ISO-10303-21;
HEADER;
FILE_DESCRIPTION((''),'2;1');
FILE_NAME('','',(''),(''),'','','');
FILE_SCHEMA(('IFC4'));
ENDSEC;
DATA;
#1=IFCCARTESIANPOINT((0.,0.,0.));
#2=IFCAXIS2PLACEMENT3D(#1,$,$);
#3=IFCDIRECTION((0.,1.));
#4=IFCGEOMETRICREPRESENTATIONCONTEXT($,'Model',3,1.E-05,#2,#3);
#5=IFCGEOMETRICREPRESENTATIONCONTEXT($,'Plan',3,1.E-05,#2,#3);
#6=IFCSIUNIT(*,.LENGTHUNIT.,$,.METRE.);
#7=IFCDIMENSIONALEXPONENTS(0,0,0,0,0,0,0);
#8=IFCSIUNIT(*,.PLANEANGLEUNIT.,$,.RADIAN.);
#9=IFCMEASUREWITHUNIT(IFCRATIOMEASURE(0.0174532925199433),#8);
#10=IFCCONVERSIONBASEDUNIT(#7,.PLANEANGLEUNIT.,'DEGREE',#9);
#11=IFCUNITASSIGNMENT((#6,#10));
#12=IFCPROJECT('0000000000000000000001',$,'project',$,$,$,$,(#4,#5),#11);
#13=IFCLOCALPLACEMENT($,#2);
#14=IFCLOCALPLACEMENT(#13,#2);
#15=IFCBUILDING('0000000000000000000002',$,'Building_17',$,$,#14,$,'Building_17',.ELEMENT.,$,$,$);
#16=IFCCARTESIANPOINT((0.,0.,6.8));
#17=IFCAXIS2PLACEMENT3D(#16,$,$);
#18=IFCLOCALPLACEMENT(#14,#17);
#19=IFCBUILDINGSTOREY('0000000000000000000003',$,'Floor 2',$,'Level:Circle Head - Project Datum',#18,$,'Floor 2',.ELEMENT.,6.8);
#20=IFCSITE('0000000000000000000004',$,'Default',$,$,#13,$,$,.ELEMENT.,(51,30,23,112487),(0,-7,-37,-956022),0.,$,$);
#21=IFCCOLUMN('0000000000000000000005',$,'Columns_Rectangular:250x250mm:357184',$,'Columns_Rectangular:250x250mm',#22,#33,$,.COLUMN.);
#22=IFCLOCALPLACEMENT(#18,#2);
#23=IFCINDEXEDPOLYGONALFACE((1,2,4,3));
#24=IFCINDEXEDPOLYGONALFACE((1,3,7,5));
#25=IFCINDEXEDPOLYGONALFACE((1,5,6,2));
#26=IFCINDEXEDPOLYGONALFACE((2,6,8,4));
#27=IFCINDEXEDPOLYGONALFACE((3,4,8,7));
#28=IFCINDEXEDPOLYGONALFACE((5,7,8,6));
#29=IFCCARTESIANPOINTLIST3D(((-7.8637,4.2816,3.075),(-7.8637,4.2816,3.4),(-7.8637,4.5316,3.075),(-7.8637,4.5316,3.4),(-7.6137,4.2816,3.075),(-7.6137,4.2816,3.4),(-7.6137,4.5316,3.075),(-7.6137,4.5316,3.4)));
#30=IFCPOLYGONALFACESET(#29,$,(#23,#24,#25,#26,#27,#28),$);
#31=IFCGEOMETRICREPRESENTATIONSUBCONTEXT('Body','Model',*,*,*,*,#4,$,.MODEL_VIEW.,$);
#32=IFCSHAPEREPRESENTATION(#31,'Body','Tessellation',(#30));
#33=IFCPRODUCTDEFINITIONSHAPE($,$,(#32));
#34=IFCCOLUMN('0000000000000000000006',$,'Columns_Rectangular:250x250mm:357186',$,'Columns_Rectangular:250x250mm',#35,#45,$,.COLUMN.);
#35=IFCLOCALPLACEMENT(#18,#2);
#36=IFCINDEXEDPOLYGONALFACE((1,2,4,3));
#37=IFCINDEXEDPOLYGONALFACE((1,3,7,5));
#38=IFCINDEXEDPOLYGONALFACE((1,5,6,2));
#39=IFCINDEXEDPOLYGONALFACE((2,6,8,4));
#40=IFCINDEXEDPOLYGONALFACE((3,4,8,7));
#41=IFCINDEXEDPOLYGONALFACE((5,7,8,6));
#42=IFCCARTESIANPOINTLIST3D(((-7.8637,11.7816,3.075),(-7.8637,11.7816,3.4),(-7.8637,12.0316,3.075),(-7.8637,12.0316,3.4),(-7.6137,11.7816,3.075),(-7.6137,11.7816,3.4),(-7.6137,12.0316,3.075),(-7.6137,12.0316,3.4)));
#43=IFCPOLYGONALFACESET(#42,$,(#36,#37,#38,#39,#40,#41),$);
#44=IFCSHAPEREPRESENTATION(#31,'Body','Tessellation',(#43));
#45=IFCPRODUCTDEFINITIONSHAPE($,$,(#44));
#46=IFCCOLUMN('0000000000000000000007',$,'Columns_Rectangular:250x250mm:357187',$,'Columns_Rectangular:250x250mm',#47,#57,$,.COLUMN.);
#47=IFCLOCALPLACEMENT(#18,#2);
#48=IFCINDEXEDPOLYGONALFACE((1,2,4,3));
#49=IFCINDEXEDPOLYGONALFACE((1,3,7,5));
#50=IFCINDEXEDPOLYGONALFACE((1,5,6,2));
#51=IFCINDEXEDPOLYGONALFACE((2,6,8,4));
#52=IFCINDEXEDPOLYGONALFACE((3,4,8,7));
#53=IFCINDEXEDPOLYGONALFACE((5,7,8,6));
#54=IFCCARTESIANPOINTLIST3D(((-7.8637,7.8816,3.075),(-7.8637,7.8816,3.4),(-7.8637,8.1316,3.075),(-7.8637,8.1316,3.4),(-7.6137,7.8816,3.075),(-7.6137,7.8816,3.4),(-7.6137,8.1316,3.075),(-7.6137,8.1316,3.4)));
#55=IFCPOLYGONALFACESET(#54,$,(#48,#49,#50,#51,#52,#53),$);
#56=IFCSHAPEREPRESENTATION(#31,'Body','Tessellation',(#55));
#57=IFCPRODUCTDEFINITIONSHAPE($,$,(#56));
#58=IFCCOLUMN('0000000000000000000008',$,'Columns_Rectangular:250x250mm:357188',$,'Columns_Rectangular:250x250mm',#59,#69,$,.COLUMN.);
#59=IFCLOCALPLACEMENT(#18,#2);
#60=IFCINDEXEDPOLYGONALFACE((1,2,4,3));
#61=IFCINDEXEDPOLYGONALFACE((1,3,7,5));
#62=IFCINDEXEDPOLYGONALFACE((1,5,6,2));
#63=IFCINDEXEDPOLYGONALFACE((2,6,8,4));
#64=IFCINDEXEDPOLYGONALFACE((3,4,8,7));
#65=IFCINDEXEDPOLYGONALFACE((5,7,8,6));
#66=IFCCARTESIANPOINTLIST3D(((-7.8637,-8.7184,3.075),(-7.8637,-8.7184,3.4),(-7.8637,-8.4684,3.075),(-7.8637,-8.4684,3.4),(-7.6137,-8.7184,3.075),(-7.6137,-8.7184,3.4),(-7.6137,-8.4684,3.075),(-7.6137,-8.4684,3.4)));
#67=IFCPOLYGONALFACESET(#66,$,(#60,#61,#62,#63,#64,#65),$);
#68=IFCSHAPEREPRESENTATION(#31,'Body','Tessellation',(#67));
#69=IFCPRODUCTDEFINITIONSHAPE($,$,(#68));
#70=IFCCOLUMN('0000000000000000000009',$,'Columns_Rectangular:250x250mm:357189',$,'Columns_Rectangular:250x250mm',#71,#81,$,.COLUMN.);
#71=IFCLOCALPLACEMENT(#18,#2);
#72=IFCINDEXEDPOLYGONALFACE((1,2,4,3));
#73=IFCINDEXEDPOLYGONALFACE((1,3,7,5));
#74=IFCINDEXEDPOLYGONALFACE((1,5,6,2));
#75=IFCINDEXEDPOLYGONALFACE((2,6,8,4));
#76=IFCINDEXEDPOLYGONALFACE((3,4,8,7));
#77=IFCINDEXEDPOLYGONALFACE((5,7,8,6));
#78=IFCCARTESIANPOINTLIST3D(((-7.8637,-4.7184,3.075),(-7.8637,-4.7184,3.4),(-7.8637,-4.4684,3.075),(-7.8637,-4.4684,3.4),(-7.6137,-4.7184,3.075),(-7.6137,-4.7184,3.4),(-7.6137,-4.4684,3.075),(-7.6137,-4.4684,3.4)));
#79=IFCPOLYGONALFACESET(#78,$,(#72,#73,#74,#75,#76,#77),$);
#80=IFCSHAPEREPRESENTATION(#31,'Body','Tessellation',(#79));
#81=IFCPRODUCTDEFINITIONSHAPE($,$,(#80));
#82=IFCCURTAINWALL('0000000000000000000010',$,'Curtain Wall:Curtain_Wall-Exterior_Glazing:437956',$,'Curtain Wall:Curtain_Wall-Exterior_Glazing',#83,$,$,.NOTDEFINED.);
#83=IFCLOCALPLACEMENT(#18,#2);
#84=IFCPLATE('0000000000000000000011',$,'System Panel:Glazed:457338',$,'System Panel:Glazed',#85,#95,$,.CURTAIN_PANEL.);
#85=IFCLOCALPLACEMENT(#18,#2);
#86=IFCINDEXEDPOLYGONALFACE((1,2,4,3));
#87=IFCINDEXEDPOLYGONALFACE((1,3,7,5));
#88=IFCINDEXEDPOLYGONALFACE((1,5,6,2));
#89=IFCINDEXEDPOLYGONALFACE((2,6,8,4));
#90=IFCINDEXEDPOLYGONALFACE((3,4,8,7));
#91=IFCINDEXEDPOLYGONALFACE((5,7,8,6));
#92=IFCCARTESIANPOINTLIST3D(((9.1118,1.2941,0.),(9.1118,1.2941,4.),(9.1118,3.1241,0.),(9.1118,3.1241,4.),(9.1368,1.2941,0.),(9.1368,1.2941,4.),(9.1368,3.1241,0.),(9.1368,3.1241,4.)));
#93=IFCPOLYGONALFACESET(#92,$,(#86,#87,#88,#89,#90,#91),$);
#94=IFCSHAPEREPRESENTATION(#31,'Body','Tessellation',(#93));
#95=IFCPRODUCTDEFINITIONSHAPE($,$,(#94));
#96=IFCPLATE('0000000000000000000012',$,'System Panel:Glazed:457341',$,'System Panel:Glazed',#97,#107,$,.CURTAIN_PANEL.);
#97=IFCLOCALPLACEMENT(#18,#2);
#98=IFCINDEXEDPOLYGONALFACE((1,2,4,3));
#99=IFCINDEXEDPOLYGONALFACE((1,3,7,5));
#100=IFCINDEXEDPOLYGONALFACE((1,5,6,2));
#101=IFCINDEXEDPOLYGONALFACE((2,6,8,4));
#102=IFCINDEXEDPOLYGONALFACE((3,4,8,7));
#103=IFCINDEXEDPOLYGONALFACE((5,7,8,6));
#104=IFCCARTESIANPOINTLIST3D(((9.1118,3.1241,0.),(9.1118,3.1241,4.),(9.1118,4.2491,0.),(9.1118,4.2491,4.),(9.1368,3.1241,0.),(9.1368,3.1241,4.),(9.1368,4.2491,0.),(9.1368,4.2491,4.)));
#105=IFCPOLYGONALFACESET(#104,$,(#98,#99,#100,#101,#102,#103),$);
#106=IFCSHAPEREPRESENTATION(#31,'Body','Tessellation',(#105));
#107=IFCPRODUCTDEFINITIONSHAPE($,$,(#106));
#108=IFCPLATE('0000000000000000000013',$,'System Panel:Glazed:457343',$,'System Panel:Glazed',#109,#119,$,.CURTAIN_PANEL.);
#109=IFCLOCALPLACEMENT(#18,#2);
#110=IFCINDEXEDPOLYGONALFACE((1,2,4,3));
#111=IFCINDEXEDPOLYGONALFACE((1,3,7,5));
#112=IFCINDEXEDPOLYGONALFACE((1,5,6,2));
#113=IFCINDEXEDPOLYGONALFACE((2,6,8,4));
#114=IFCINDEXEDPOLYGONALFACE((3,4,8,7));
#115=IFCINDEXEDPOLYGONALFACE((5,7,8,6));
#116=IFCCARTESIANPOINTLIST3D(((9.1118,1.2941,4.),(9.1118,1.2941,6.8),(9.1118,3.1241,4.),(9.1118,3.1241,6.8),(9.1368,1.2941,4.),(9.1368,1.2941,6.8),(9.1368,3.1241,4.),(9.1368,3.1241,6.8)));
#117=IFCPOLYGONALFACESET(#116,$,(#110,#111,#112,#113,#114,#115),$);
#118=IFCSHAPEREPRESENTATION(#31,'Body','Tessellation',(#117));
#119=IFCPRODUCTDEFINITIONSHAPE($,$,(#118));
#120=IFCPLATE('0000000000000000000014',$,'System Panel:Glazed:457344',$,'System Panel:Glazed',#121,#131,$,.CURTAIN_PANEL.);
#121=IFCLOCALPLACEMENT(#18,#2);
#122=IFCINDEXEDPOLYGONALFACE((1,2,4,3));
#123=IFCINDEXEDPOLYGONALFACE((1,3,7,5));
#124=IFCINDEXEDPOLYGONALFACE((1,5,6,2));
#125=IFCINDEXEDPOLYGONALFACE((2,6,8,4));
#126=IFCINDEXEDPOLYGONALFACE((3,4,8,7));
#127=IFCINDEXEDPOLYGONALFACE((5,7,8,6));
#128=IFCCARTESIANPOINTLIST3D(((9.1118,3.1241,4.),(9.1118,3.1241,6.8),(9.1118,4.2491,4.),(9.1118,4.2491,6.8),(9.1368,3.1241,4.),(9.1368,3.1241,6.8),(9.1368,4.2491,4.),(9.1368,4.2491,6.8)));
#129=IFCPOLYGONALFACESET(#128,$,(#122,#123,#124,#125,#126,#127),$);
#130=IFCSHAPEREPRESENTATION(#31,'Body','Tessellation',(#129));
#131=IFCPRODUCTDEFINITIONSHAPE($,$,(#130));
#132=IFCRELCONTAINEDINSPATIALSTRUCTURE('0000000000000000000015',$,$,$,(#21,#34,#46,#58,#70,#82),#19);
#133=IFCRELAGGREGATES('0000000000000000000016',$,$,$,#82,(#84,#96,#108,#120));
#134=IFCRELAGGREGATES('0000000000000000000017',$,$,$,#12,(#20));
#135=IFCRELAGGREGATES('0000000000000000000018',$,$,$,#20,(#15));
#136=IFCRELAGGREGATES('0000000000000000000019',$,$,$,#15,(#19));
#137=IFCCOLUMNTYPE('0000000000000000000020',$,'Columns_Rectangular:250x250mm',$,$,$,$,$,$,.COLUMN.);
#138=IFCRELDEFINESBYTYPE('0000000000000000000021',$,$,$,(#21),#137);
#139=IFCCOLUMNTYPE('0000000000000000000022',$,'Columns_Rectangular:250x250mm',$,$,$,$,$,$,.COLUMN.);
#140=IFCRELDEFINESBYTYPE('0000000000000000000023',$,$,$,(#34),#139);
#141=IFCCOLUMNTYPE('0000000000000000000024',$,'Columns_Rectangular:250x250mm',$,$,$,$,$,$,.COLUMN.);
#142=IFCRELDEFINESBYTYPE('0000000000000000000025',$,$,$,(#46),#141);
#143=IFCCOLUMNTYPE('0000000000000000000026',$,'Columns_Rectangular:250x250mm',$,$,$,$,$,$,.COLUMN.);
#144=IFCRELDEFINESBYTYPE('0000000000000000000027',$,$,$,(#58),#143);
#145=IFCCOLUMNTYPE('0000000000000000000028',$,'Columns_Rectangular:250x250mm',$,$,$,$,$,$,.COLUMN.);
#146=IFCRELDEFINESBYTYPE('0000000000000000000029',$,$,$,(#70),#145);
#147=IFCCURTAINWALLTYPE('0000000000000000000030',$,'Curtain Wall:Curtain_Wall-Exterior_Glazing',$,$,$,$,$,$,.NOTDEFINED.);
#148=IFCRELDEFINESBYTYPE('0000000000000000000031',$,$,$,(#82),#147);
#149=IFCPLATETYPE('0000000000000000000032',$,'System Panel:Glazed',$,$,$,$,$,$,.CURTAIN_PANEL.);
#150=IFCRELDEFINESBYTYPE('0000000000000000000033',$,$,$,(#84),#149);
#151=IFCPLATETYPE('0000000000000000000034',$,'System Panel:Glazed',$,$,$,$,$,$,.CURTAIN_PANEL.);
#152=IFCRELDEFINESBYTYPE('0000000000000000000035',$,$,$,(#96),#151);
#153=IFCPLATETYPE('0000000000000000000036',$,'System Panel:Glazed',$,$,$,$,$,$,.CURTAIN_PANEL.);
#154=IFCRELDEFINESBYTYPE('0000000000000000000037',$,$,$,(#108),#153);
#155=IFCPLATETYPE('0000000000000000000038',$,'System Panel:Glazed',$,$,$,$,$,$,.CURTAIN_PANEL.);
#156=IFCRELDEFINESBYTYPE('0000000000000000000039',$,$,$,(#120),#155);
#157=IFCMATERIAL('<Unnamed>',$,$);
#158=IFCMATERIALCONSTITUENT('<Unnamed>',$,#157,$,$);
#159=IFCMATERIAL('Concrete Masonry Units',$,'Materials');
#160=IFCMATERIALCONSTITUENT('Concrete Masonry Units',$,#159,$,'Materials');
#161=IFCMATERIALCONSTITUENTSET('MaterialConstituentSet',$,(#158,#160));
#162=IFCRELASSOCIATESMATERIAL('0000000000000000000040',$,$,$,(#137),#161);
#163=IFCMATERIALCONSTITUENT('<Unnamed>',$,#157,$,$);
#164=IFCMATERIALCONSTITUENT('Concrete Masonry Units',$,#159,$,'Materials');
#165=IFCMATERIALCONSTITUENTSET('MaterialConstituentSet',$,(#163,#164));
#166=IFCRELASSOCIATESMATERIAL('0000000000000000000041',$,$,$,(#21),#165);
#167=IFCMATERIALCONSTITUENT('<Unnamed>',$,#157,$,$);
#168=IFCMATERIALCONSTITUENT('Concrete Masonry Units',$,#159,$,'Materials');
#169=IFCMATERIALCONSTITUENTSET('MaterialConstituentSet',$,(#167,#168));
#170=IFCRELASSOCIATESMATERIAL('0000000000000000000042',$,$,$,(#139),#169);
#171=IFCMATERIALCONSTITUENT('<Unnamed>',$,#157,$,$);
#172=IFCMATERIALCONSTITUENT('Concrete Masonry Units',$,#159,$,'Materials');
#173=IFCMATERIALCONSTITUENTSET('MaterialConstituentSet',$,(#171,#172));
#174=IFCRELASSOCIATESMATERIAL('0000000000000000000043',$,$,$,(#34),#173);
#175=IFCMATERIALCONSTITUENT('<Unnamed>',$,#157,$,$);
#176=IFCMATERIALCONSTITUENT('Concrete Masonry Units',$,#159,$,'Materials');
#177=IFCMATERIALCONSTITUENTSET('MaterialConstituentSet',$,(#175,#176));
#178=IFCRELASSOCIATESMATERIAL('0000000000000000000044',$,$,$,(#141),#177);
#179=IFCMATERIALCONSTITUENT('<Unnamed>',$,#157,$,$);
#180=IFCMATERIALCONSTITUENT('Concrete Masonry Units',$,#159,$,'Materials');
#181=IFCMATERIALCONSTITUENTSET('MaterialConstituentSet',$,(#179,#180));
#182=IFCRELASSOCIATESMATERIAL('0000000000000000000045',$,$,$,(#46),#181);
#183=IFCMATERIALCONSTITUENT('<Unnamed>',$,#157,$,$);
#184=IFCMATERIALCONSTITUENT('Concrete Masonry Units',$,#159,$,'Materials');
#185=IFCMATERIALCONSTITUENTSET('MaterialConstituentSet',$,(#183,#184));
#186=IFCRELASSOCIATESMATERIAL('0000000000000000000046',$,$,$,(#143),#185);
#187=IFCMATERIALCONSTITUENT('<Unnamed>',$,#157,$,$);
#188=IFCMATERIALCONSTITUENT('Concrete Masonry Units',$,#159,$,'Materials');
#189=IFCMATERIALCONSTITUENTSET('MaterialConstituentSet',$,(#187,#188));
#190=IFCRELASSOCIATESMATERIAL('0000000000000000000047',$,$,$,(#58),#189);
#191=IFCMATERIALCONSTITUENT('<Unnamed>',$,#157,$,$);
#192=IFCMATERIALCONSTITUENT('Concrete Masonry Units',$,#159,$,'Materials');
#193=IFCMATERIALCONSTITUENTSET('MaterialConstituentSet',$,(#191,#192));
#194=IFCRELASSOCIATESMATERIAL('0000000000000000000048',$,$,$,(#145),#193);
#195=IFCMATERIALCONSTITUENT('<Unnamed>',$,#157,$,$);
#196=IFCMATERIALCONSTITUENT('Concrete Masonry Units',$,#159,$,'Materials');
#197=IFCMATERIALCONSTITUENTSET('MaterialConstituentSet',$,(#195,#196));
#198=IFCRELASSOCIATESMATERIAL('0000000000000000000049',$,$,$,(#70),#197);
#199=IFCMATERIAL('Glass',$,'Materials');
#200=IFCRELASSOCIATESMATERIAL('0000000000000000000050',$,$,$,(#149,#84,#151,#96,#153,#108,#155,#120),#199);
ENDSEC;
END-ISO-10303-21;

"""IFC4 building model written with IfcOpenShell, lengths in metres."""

from ifc_helpers import new_model, entity, si_unit, converted_unit, direction, frame, origin, place, context, subcontext, project, spatial, indexed_curve, outline, extrude, source, transform, mapped, material, constituent, constituent_set, type_object, type_shapes, element, aggregate, save


model = new_model("IFC4")

# Units and contexts
model_context = context("Model", 3, precision=1e-05, world=origin(), true_north=direction((0.0, 1.0)))
plan_context = context("Plan", 3, precision=1e-05, world=origin(), true_north=direction((0.0, 1.0)))
body_context = subcontext(model_context, "Body", "Model", "MODEL_VIEW")
ifc_project = project(units=[si_unit("LENGTHUNIT", "METRE"), converted_unit("PLANEANGLEUNIT", "DEGREE", entity("IfcRatioMeasure", 0.0174532925199433), si_unit("PLANEANGLEUNIT", "RADIAN"), dimensions=[0, 0, 0, 0, 0, 0, 0])], contexts=[model_context, plan_context])

# Site, building, storey
site_placement = place(None, origin())
site = spatial("IfcSite", under=ifc_project, at=site_placement, Name="Default", CompositionType="ELEMENT", RefLatitude=(51, 30, 23, 112487), RefLongitude=(0, -7, -37, -956022), RefElevation=0.0)
building_placement = place(site_placement, origin())
building = spatial("IfcBuilding", under=site, at=building_placement, Name="Building_17", LongName="Building_17", CompositionType="ELEMENT")
storey_placement = place(building_placement, frame((0.0, 0.0, 6.8)))
storey = spatial("IfcBuildingStorey", under=building, at=storey_placement, Name="Floor 2", ObjectType="Level:Circle Head - Project Datum", LongName="Floor 2", CompositionType="ELEMENT", Elevation=6.8)

# Columns
ifc_material_1 = material(Name="<Unnamed>")
ifc_material_2 = material(Name="Concrete Masonry Units", Category="Materials")
ifc_constituent_1 = constituent(ifc_material_1, Name="<Unnamed>")
ifc_constituent_2 = constituent(ifc_material_2, Name="Concrete Masonry Units", Category="Materials")
ifc_constituent_set_1 = constituent_set(constituents=[ifc_constituent_1, ifc_constituent_2], Name="MaterialConstituentSet")
ifc_constituent_3 = constituent(ifc_material_1, Name="<Unnamed>")
ifc_constituent_4 = constituent(ifc_material_2, Name="Concrete Masonry Units", Category="Materials")
ifc_constituent_set_2 = constituent_set(constituents=[ifc_constituent_3, ifc_constituent_4], Name="MaterialConstituentSet")
column_type_1 = type_object("IfcColumnType", Name="Columns_Rectangular:250x250mm", PredefinedType="COLUMN", material=ifc_constituent_set_2)
shared_shape_1 = source(origin(), body_context, "Body", "SweptSolid", [
    extrude(outline(indexed_curve([(-0.125, -0.125), (0.125, -0.125), (0.125, 0.125), (-0.125, 0.125), (-0.125, -0.125)], self_intersect=False)), frame((-7.7387, 4.4066, 9.875), z_axis=(0.0, 0.0, 1.0), x_axis=(0.0, -1.0, 0.0)), (0.0, 0.0, 1.0), 0.325),
])
type_shapes(column_type_1, [shared_shape_1])
column_1_placement = place(storey_placement, frame((0.0, 0.0, -6.8)))
element("IfcColumn", 1, at=column_1_placement, inside=storey, type_object=column_type_1, material=ifc_constituent_set_1, Name="Columns_Rectangular:250x250mm:357184", ObjectType="Columns_Rectangular:250x250mm", PredefinedType="COLUMN", context=body_context, shape_type="MappedRepresentation", body=[
    mapped(shared_shape_1, transform((0.0, 0.0, 0.0), scale=1.0)),
])
ifc_constituent_5 = constituent(ifc_material_1, Name="<Unnamed>")
ifc_constituent_6 = constituent(ifc_material_2, Name="Concrete Masonry Units", Category="Materials")
ifc_constituent_set_3 = constituent_set(constituents=[ifc_constituent_5, ifc_constituent_6], Name="MaterialConstituentSet")
ifc_constituent_7 = constituent(ifc_material_1, Name="<Unnamed>")
ifc_constituent_8 = constituent(ifc_material_2, Name="Concrete Masonry Units", Category="Materials")
ifc_constituent_set_4 = constituent_set(constituents=[ifc_constituent_7, ifc_constituent_8], Name="MaterialConstituentSet")
column_type_2 = type_object("IfcColumnType", Name="Columns_Rectangular:250x250mm", PredefinedType="COLUMN", material=ifc_constituent_set_4)
shared_shape_2 = source(origin(), body_context, "Body", "SweptSolid", [
    extrude(outline(indexed_curve([(-0.125, -0.125), (0.125, -0.125), (0.125, 0.125), (-0.125, 0.125), (-0.125, -0.125)], self_intersect=False)), frame((-7.7387, 11.9066, 9.875), z_axis=(0.0, 0.0, 1.0), x_axis=(0.0, -1.0, 0.0)), (0.0, 0.0, 1.0), 0.325),
])
type_shapes(column_type_2, [shared_shape_2])
column_2_placement = place(storey_placement, frame((0.0, 0.0, -6.8)))
element("IfcColumn", 2, at=column_2_placement, inside=storey, type_object=column_type_2, material=ifc_constituent_set_3, Name="Columns_Rectangular:250x250mm:357186", ObjectType="Columns_Rectangular:250x250mm", PredefinedType="COLUMN", context=body_context, shape_type="MappedRepresentation", body=[
    mapped(shared_shape_2, transform((0.0, 0.0, 0.0), scale=1.0)),
])
ifc_constituent_9 = constituent(ifc_material_1, Name="<Unnamed>")
ifc_constituent_10 = constituent(ifc_material_2, Name="Concrete Masonry Units", Category="Materials")
ifc_constituent_set_5 = constituent_set(constituents=[ifc_constituent_9, ifc_constituent_10], Name="MaterialConstituentSet")
ifc_constituent_11 = constituent(ifc_material_1, Name="<Unnamed>")
ifc_constituent_12 = constituent(ifc_material_2, Name="Concrete Masonry Units", Category="Materials")
ifc_constituent_set_6 = constituent_set(constituents=[ifc_constituent_11, ifc_constituent_12], Name="MaterialConstituentSet")
column_type_3 = type_object("IfcColumnType", Name="Columns_Rectangular:250x250mm", PredefinedType="COLUMN", material=ifc_constituent_set_6)
shared_shape_3 = source(origin(), body_context, "Body", "SweptSolid", [
    extrude(outline(indexed_curve([(-0.125, -0.125), (0.125, -0.125), (0.125, 0.125), (-0.125, 0.125), (-0.125, -0.125)], self_intersect=False)), frame((-7.7387, 8.0066, 9.875), z_axis=(0.0, 0.0, 1.0), x_axis=(0.0, -1.0, 0.0)), (0.0, 0.0, 1.0), 0.325),
])
type_shapes(column_type_3, [shared_shape_3])
column_3_placement = place(storey_placement, frame((0.0, 0.0, -6.8)))
element("IfcColumn", 3, at=column_3_placement, inside=storey, type_object=column_type_3, material=ifc_constituent_set_5, Name="Columns_Rectangular:250x250mm:357187", ObjectType="Columns_Rectangular:250x250mm", PredefinedType="COLUMN", context=body_context, shape_type="MappedRepresentation", body=[
    mapped(shared_shape_3, transform((0.0, 0.0, 0.0), scale=1.0)),
])
ifc_constituent_13 = constituent(ifc_material_1, Name="<Unnamed>")
ifc_constituent_14 = constituent(ifc_material_2, Name="Concrete Masonry Units", Category="Materials")
ifc_constituent_set_7 = constituent_set(constituents=[ifc_constituent_13, ifc_constituent_14], Name="MaterialConstituentSet")
ifc_constituent_15 = constituent(ifc_material_1, Name="<Unnamed>")
ifc_constituent_16 = constituent(ifc_material_2, Name="Concrete Masonry Units", Category="Materials")
ifc_constituent_set_8 = constituent_set(constituents=[ifc_constituent_15, ifc_constituent_16], Name="MaterialConstituentSet")
column_type_4 = type_object("IfcColumnType", Name="Columns_Rectangular:250x250mm", PredefinedType="COLUMN", material=ifc_constituent_set_8)
shared_shape_4 = source(origin(), body_context, "Body", "SweptSolid", [
    extrude(outline(indexed_curve([(-0.125, -0.125), (0.125, -0.125), (0.125, 0.125), (-0.125, 0.125), (-0.125, -0.125)], self_intersect=False)), frame((-7.7387, -8.5934, 9.875), z_axis=(0.0, 0.0, 1.0), x_axis=(0.0, -1.0, 0.0)), (0.0, 0.0, 1.0), 0.325),
])
type_shapes(column_type_4, [shared_shape_4])
column_4_placement = place(storey_placement, frame((0.0, 0.0, -6.8)))
element("IfcColumn", 4, at=column_4_placement, inside=storey, type_object=column_type_4, material=ifc_constituent_set_7, Name="Columns_Rectangular:250x250mm:357188", ObjectType="Columns_Rectangular:250x250mm", PredefinedType="COLUMN", context=body_context, shape_type="MappedRepresentation", body=[
    mapped(shared_shape_4, transform((0.0, 0.0, 0.0), scale=1.0)),
])
ifc_constituent_17 = constituent(ifc_material_1, Name="<Unnamed>")
ifc_constituent_18 = constituent(ifc_material_2, Name="Concrete Masonry Units", Category="Materials")
ifc_constituent_set_9 = constituent_set(constituents=[ifc_constituent_17, ifc_constituent_18], Name="MaterialConstituentSet")
ifc_constituent_19 = constituent(ifc_material_1, Name="<Unnamed>")
ifc_constituent_20 = constituent(ifc_material_2, Name="Concrete Masonry Units", Category="Materials")
ifc_constituent_set_10 = constituent_set(constituents=[ifc_constituent_19, ifc_constituent_20], Name="MaterialConstituentSet")
column_type_5 = type_object("IfcColumnType", Name="Columns_Rectangular:250x250mm", PredefinedType="COLUMN", material=ifc_constituent_set_10)
shared_shape_5 = source(origin(), body_context, "Body", "SweptSolid", [
    extrude(outline(indexed_curve([(-0.125, -0.125), (0.125, -0.125), (0.125, 0.125), (-0.125, 0.125), (-0.125, -0.125)], self_intersect=False)), frame((-7.7387, -4.5934, 9.875), z_axis=(0.0, 0.0, 1.0), x_axis=(0.0, -1.0, 0.0)), (0.0, 0.0, 1.0), 0.325),
])
type_shapes(column_type_5, [shared_shape_5])
column_5_placement = place(storey_placement, frame((0.0, 0.0, -6.8)))
element("IfcColumn", 5, at=column_5_placement, inside=storey, type_object=column_type_5, material=ifc_constituent_set_9, Name="Columns_Rectangular:250x250mm:357189", ObjectType="Columns_Rectangular:250x250mm", PredefinedType="COLUMN", context=body_context, shape_type="MappedRepresentation", body=[
    mapped(shared_shape_5, transform((0.0, 0.0, 0.0), scale=1.0)),
])

# Curtain wall, plates
curtain_wall_type = type_object("IfcCurtainWallType", Name="Curtain Wall:Curtain_Wall-Exterior_Glazing", PredefinedType="NOTDEFINED")
curtain_wall_placement = place(storey_placement, frame((0.0, 0.0, -6.8)))
curtain_wall = element("IfcCurtainWall", 6, at=curtain_wall_placement, inside=storey, type_object=curtain_wall_type, Name="Curtain Wall:Curtain_Wall-Exterior_Glazing:437956", ObjectType="Curtain Wall:Curtain_Wall-Exterior_Glazing", PredefinedType="NOTDEFINED")
ifc_material_3 = material(Name="Glass", Category="Materials")
plate_type_1 = type_object("IfcPlateType", Name="System Panel:Glazed", PredefinedType="CURTAIN_PANEL", material=ifc_material_3)
shared_shape_6 = source(origin(), body_context, "Body", "SweptSolid", [
    extrude(outline(indexed_curve([(-0.0125, -0.915), (0.0125, -0.915), (0.0125, 0.915), (-0.0125, 0.915), (-0.0125, -0.915)], self_intersect=False)), frame((0.0, 0.037, 0.0), z_axis=(0.0, 0.0, 1.0), x_axis=(0.0, 1.0, 0.0)), (0.0, 0.0, 1.0), 4.0),
])
type_shapes(plate_type_1, [shared_shape_6])
plate_1_placement = place(curtain_wall_placement, frame((9.1613, 2.2091, 6.8), z_axis=(0.0, 0.0, 1.0), x_axis=(0.0, 1.0, 0.0)))
plate_1 = element("IfcPlate", 7, at=plate_1_placement, type_object=plate_type_1, material=ifc_material_3, Name="System Panel:Glazed:457338", ObjectType="System Panel:Glazed", PredefinedType="CURTAIN_PANEL", context=body_context, shape_type="MappedRepresentation", body=[
    mapped(shared_shape_6, transform((0.0, 0.0, 0.0), scale=1.0)),
])
plate_type_2 = type_object("IfcPlateType", Name="System Panel:Glazed", PredefinedType="CURTAIN_PANEL", material=ifc_material_3)
shared_shape_7 = source(origin(), body_context, "Body", "SweptSolid", [
    extrude(outline(indexed_curve([(-0.0125, -0.5625), (0.0125, -0.5625), (0.0125, 0.5625), (-0.0125, 0.5625), (-0.0125, -0.5625)], self_intersect=False)), frame((0.0, 0.037, 0.0), z_axis=(0.0, 0.0, 1.0), x_axis=(0.0, 1.0, 0.0)), (0.0, 0.0, 1.0), 4.0),
])
type_shapes(plate_type_2, [shared_shape_7])
plate_2_placement = place(curtain_wall_placement, frame((9.1613, 3.6866, 6.8), z_axis=(0.0, 0.0, 1.0), x_axis=(0.0, 1.0, 0.0)))
plate_2 = element("IfcPlate", 8, at=plate_2_placement, type_object=plate_type_2, material=ifc_material_3, Name="System Panel:Glazed:457341", ObjectType="System Panel:Glazed", PredefinedType="CURTAIN_PANEL", context=body_context, shape_type="MappedRepresentation", body=[
    mapped(shared_shape_7, transform((0.0, 0.0, 0.0), scale=1.0)),
])
plate_type_3 = type_object("IfcPlateType", Name="System Panel:Glazed", PredefinedType="CURTAIN_PANEL", material=ifc_material_3)
shared_shape_8 = source(origin(), body_context, "Body", "SweptSolid", [
    extrude(outline(indexed_curve([(-0.0125, -0.915), (0.0125, -0.915), (0.0125, 0.915), (-0.0125, 0.915), (-0.0125, -0.915)], self_intersect=False)), frame((0.0, 0.037, 0.0), z_axis=(0.0, 0.0, 1.0), x_axis=(0.0, 1.0, 0.0)), (0.0, 0.0, 1.0), 2.8),
])
type_shapes(plate_type_3, [shared_shape_8])
plate_3_placement = place(curtain_wall_placement, frame((9.1613, 2.2091, 10.8), z_axis=(0.0, 0.0, 1.0), x_axis=(0.0, 1.0, 0.0)))
plate_3 = element("IfcPlate", 9, at=plate_3_placement, type_object=plate_type_3, material=ifc_material_3, Name="System Panel:Glazed:457343", ObjectType="System Panel:Glazed", PredefinedType="CURTAIN_PANEL", context=body_context, shape_type="MappedRepresentation", body=[
    mapped(shared_shape_8, transform((0.0, 0.0, 0.0), scale=1.0)),
])
plate_type_4 = type_object("IfcPlateType", Name="System Panel:Glazed", PredefinedType="CURTAIN_PANEL", material=ifc_material_3)
shared_shape_9 = source(origin(), body_context, "Body", "SweptSolid", [
    extrude(outline(indexed_curve([(-0.0125, -0.5625), (0.0125, -0.5625), (0.0125, 0.5625), (-0.0125, 0.5625), (-0.0125, -0.5625)], self_intersect=False)), frame((0.0, 0.037, 0.0), z_axis=(0.0, 0.0, 1.0), x_axis=(0.0, 1.0, 0.0)), (0.0, 0.0, 1.0), 2.8),
])
type_shapes(plate_type_4, [shared_shape_9])
plate_4_placement = place(curtain_wall_placement, frame((9.1613, 3.6866, 10.8), z_axis=(0.0, 0.0, 1.0), x_axis=(0.0, 1.0, 0.0)))
plate_4 = element("IfcPlate", 10, at=plate_4_placement, type_object=plate_type_4, material=ifc_material_3, Name="System Panel:Glazed:457344", ObjectType="System Panel:Glazed", PredefinedType="CURTAIN_PANEL", context=body_context, shape_type="MappedRepresentation", body=[
    mapped(shared_shape_9, transform((0.0, 0.0, 0.0), scale=1.0)),
])
aggregate(curtain_wall, [plate_1, plate_2, plate_3, plate_4])

save(model, "model.ifc")
